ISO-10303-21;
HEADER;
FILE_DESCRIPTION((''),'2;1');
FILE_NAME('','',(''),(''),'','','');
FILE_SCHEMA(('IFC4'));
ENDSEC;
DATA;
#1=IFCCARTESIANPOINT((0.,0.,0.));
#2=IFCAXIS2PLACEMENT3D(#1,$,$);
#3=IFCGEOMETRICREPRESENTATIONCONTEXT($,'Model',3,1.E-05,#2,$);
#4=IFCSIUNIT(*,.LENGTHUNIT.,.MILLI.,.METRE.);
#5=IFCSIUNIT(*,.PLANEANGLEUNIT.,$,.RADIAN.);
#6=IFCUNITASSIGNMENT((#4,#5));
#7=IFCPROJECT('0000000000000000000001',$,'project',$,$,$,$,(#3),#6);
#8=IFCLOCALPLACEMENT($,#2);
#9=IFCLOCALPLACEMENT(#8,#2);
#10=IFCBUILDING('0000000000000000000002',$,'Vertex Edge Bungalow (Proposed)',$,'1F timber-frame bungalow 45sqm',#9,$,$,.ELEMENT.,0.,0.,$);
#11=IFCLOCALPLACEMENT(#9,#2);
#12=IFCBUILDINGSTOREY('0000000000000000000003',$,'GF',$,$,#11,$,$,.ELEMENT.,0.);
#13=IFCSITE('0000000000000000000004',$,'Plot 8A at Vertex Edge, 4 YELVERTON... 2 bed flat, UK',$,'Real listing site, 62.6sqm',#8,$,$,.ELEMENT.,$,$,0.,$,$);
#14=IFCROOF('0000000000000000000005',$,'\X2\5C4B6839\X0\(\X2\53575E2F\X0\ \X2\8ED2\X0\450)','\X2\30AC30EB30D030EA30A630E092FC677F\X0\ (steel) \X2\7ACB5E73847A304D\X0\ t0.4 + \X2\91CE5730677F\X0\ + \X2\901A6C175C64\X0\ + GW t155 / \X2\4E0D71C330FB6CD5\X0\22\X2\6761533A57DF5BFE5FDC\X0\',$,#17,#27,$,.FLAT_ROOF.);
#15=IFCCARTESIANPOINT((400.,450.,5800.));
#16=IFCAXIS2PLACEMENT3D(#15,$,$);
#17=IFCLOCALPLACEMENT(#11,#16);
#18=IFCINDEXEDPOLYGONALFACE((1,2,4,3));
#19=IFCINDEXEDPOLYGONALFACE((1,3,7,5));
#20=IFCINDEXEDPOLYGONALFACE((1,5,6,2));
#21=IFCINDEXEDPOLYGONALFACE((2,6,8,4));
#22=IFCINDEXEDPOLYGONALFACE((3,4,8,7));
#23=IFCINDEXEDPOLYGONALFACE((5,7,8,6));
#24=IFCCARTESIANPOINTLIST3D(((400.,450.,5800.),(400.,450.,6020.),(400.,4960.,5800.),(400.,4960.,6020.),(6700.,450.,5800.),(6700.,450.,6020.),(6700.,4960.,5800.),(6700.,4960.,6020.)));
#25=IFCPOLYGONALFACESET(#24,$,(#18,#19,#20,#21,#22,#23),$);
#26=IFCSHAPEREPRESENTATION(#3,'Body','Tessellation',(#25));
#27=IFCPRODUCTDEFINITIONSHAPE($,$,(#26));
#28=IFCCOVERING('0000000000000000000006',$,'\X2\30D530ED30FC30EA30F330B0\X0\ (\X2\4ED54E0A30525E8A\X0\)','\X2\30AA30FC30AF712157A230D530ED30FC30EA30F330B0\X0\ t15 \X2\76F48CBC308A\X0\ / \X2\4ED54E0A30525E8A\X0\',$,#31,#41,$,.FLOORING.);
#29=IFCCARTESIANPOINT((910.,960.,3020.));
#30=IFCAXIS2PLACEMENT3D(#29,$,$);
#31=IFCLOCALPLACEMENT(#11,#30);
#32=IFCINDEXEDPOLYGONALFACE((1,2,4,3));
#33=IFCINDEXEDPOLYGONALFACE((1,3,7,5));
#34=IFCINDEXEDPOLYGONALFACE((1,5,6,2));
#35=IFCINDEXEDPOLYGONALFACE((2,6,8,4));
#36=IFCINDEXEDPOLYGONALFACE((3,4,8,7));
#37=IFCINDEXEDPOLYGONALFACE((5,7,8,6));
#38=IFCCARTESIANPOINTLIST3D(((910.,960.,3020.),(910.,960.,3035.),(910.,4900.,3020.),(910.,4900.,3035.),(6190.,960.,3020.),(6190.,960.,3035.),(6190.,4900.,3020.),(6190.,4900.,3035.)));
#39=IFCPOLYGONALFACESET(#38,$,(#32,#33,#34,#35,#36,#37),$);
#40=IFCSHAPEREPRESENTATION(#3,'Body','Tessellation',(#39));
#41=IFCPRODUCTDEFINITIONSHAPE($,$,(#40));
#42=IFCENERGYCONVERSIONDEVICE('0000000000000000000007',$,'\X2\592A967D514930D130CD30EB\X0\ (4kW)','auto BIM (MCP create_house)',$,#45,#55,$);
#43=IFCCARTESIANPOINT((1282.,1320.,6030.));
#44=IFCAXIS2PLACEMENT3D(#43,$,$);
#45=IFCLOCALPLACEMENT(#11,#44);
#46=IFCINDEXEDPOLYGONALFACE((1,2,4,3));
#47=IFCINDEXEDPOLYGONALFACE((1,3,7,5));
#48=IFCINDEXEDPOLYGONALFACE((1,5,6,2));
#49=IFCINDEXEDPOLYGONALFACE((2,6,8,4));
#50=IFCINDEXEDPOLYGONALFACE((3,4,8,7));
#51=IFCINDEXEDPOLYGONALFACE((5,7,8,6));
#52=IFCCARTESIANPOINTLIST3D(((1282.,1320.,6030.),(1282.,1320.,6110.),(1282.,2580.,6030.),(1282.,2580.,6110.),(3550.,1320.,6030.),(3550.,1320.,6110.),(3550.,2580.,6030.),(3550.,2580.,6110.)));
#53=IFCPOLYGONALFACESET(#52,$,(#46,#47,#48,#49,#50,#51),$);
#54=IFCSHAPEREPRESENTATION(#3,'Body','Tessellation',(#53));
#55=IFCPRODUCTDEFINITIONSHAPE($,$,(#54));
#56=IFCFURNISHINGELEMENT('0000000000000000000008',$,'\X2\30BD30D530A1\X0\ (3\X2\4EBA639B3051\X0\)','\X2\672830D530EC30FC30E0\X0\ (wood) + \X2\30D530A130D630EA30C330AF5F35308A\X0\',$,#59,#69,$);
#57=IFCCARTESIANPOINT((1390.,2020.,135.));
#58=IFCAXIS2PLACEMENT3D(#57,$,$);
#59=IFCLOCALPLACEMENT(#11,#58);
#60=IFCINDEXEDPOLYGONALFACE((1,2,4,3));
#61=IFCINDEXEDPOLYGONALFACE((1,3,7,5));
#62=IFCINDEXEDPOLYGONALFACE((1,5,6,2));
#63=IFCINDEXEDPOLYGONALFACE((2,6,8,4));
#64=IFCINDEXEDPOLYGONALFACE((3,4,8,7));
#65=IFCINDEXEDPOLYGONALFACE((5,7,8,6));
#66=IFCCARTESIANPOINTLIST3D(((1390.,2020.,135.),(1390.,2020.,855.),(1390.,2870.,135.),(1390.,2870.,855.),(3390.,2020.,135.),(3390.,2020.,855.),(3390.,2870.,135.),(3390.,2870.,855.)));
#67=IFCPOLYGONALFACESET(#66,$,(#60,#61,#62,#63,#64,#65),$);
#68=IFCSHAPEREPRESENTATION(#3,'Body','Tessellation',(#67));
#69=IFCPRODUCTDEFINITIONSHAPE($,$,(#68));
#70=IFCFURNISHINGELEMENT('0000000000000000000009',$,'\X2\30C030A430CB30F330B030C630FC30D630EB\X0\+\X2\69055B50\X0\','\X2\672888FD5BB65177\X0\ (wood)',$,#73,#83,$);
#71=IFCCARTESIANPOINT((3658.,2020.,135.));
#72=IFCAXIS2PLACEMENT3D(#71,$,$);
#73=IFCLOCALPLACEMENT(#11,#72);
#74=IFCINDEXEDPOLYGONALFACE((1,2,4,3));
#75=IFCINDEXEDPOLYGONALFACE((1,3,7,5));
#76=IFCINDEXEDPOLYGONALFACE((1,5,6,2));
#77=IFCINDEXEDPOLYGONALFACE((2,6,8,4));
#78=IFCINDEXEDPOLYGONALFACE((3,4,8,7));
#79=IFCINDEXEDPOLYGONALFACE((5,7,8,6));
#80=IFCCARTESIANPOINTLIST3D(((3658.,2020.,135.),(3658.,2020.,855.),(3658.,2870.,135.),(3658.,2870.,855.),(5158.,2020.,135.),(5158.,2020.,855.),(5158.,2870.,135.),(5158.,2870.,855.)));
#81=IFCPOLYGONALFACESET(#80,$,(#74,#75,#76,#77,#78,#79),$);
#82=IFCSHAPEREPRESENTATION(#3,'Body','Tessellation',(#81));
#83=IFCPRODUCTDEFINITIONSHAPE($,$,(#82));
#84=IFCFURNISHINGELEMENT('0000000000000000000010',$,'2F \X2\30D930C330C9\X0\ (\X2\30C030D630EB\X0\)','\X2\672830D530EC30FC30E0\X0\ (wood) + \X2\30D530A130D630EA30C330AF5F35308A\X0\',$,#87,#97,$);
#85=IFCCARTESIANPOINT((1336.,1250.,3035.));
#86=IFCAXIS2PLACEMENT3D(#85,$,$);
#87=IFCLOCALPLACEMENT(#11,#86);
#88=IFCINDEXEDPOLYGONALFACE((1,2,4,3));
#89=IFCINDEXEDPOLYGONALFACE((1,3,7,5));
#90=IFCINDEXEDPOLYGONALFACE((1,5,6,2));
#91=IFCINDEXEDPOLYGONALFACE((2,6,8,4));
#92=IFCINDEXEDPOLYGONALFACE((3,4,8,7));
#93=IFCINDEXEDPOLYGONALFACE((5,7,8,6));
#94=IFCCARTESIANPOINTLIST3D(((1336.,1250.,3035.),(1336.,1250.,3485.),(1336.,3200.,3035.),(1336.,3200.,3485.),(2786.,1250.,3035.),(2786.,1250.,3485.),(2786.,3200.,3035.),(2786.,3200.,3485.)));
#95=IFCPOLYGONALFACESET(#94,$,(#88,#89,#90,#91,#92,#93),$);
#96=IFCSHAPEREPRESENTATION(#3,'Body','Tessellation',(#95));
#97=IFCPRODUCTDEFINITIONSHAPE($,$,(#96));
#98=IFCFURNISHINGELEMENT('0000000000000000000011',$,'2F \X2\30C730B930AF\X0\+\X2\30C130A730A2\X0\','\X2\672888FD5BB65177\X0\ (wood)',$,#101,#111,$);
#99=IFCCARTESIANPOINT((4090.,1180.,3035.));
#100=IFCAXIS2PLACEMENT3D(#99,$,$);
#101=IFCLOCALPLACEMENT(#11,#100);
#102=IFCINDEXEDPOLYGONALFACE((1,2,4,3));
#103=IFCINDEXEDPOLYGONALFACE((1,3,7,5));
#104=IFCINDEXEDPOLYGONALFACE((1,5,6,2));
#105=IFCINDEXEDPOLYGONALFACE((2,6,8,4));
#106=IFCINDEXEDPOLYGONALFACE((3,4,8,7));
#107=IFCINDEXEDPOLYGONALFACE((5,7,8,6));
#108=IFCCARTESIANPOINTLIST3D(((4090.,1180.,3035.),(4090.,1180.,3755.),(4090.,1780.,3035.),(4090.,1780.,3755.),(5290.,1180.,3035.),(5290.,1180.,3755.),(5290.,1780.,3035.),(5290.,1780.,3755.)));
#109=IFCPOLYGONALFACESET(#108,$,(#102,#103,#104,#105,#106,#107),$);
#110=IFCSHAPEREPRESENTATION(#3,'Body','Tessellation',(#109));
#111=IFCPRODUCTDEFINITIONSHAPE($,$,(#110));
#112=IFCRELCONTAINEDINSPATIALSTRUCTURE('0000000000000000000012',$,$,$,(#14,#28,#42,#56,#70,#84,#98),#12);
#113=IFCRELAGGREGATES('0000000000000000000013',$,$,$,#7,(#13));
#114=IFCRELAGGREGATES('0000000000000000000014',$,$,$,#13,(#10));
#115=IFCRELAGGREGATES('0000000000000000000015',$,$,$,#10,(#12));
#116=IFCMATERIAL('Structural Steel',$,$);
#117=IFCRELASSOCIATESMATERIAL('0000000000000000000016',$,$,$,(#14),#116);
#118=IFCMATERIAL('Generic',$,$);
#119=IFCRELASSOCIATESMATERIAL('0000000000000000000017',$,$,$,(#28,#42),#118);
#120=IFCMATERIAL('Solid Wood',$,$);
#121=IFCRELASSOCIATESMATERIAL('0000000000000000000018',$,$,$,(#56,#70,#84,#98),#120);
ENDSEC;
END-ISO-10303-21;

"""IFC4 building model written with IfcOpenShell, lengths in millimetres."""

from ifc_helpers import new_model, si_unit, frame, frame_2d, origin, place, context, project, spatial, rectangle, extrude, material, element, save


model = new_model("IFC4")

# Units and contexts
model_context = context("Model", 3, precision=1e-05, world=origin())
ifc_project = project(units=[si_unit("LENGTHUNIT", "METRE", prefix="MILLI"), si_unit("PLANEANGLEUNIT", "RADIAN")], contexts=[model_context])

# Site, building, storey
site_placement = place(None, origin())
site = spatial("IfcSite", under=ifc_project, at=site_placement, Name="Plot 8A at Vertex Edge, 4 YELVERTON... 2 bed flat, UK", ObjectType="Real listing site, 62.6sqm", CompositionType="ELEMENT", RefElevation=0.0)
building_placement = place(site_placement, origin())
building = spatial("IfcBuilding", under=site, at=building_placement, Name="Vertex Edge Bungalow (Proposed)", ObjectType="1F timber-frame bungalow 45sqm", CompositionType="ELEMENT", ElevationOfRefHeight=0.0, ElevationOfTerrain=0.0)
storey_placement = place(building_placement, origin())
storey = spatial("IfcBuildingStorey", under=building, at=storey_placement, Name="GF", CompositionType="ELEMENT", Elevation=0.0)

# Shared definitions
ifc_material_1 = material(Name="Solid Wood")

# Shared definitions
ifc_material_2 = material(Name="Generic")

# Roof
ifc_material_3 = material(Name="Structural Steel")
for number, where, name in (
    (1, (400.0, 450.0, 5800.0), "屋根(南帯 軒450)"),
):
    element("IfcRoof", number, at=place(storey_placement, frame(where)), inside=storey, material=ifc_material_3, Name=name, Description="ガルバリウム鋼板 (steel) 立平葺き t0.4 + 野地板 + 通気層 + GW t155 / 不燃・法22条区域対応", PredefinedType="FLAT_ROOF", context=model_context, shape_type="SweptSolid", body=[
        extrude(rectangle(XDim=6300.0, YDim=4510.0, at=frame_2d((3150.0, 2255.0))), frame((400.0, 450.0, 5800.0)), (0.0, 0.0, 1.0), 220.0),
    ])

# Covering
covering_placement = place(storey_placement, frame((910.0, 960.0, 3020.0)))
element("IfcCovering", 2, at=covering_placement, inside=storey, material=ifc_material_2, Name="フローリング (仕上げ床)", Description="オーク無垢フローリング t15 直貼り / 仕上げ床", PredefinedType="FLOORING", context=model_context, shape_type="SweptSolid", body=[
    extrude(rectangle(XDim=5280.0, YDim=3940.0, at=frame_2d((2640.0, 1970.0))), frame((910.0, 960.0, 3020.0)), (0.0, 0.0, 1.0), 15.0),
])

# Energy conversion device
energy_conversion_device_placement = place(storey_placement, frame((1282.0, 1320.0, 6030.0)))
element("IfcEnergyConversionDevice", 3, at=energy_conversion_device_placement, inside=storey, material=ifc_material_2, Name="太陽光パネル (4kW)", Description="auto BIM (MCP create_house)", context=model_context, shape_type="SweptSolid", body=[
    extrude(rectangle(XDim=2268.0, YDim=1260.0, at=frame_2d((1134.0, 630.0))), frame((1282.0, 1320.0, 6030.0)), (0.0, 0.0, 1.0), 80.0),
])

# Furnishing elements
furnishing_1_placement = place(storey_placement, frame((1390.0, 2020.0, 135.0)))
element("IfcFurnishingElement", 4, at=furnishing_1_placement, inside=storey, material=ifc_material_1, Name="ソファ (3人掛け)", Description="木フレーム (wood) + ファブリック張り", context=model_context, shape_type="SweptSolid", body=[
    extrude(rectangle(XDim=2000.0, YDim=850.0, at=frame_2d((1000.0, 425.0))), frame((1390.0, 2020.0, 135.0)), (0.0, 0.0, 1.0), 720.0),
])
furnishing_2_placement = place(storey_placement, frame((3658.0, 2020.0, 135.0)))
element("IfcFurnishingElement", 5, at=furnishing_2_placement, inside=storey, material=ifc_material_1, Name="ダイニングテーブル+椅子", Description="木製家具 (wood)", context=model_context, shape_type="SweptSolid", body=[
    extrude(rectangle(XDim=1500.0, YDim=850.0, at=frame_2d((750.0, 425.0))), frame((3658.0, 2020.0, 135.0)), (0.0, 0.0, 1.0), 720.0),
])
furnishing_3_placement = place(storey_placement, frame((1336.0, 1250.0, 3035.0)))
element("IfcFurnishingElement", 6, at=furnishing_3_placement, inside=storey, material=ifc_material_1, Name="2F ベッド (ダブル)", Description="木フレーム (wood) + ファブリック張り", context=model_context, shape_type="SweptSolid", body=[
    extrude(rectangle(XDim=1450.0, YDim=1950.0, at=frame_2d((725.0, 975.0))), frame((1336.0, 1250.0, 3035.0)), (0.0, 0.0, 1.0), 450.0),
])
furnishing_4_placement = place(storey_placement, frame((4090.0, 1180.0, 3035.0)))
element("IfcFurnishingElement", 7, at=furnishing_4_placement, inside=storey, material=ifc_material_1, Name="2F デスク+チェア", Description="木製家具 (wood)", context=model_context, shape_type="SweptSolid", body=[
    extrude(rectangle(XDim=1200.0, YDim=600.0, at=frame_2d((600.0, 300.0))), frame((4090.0, 1180.0, 3035.0)), (0.0, 0.0, 1.0), 720.0),
])

save(model, "model.ifc")
